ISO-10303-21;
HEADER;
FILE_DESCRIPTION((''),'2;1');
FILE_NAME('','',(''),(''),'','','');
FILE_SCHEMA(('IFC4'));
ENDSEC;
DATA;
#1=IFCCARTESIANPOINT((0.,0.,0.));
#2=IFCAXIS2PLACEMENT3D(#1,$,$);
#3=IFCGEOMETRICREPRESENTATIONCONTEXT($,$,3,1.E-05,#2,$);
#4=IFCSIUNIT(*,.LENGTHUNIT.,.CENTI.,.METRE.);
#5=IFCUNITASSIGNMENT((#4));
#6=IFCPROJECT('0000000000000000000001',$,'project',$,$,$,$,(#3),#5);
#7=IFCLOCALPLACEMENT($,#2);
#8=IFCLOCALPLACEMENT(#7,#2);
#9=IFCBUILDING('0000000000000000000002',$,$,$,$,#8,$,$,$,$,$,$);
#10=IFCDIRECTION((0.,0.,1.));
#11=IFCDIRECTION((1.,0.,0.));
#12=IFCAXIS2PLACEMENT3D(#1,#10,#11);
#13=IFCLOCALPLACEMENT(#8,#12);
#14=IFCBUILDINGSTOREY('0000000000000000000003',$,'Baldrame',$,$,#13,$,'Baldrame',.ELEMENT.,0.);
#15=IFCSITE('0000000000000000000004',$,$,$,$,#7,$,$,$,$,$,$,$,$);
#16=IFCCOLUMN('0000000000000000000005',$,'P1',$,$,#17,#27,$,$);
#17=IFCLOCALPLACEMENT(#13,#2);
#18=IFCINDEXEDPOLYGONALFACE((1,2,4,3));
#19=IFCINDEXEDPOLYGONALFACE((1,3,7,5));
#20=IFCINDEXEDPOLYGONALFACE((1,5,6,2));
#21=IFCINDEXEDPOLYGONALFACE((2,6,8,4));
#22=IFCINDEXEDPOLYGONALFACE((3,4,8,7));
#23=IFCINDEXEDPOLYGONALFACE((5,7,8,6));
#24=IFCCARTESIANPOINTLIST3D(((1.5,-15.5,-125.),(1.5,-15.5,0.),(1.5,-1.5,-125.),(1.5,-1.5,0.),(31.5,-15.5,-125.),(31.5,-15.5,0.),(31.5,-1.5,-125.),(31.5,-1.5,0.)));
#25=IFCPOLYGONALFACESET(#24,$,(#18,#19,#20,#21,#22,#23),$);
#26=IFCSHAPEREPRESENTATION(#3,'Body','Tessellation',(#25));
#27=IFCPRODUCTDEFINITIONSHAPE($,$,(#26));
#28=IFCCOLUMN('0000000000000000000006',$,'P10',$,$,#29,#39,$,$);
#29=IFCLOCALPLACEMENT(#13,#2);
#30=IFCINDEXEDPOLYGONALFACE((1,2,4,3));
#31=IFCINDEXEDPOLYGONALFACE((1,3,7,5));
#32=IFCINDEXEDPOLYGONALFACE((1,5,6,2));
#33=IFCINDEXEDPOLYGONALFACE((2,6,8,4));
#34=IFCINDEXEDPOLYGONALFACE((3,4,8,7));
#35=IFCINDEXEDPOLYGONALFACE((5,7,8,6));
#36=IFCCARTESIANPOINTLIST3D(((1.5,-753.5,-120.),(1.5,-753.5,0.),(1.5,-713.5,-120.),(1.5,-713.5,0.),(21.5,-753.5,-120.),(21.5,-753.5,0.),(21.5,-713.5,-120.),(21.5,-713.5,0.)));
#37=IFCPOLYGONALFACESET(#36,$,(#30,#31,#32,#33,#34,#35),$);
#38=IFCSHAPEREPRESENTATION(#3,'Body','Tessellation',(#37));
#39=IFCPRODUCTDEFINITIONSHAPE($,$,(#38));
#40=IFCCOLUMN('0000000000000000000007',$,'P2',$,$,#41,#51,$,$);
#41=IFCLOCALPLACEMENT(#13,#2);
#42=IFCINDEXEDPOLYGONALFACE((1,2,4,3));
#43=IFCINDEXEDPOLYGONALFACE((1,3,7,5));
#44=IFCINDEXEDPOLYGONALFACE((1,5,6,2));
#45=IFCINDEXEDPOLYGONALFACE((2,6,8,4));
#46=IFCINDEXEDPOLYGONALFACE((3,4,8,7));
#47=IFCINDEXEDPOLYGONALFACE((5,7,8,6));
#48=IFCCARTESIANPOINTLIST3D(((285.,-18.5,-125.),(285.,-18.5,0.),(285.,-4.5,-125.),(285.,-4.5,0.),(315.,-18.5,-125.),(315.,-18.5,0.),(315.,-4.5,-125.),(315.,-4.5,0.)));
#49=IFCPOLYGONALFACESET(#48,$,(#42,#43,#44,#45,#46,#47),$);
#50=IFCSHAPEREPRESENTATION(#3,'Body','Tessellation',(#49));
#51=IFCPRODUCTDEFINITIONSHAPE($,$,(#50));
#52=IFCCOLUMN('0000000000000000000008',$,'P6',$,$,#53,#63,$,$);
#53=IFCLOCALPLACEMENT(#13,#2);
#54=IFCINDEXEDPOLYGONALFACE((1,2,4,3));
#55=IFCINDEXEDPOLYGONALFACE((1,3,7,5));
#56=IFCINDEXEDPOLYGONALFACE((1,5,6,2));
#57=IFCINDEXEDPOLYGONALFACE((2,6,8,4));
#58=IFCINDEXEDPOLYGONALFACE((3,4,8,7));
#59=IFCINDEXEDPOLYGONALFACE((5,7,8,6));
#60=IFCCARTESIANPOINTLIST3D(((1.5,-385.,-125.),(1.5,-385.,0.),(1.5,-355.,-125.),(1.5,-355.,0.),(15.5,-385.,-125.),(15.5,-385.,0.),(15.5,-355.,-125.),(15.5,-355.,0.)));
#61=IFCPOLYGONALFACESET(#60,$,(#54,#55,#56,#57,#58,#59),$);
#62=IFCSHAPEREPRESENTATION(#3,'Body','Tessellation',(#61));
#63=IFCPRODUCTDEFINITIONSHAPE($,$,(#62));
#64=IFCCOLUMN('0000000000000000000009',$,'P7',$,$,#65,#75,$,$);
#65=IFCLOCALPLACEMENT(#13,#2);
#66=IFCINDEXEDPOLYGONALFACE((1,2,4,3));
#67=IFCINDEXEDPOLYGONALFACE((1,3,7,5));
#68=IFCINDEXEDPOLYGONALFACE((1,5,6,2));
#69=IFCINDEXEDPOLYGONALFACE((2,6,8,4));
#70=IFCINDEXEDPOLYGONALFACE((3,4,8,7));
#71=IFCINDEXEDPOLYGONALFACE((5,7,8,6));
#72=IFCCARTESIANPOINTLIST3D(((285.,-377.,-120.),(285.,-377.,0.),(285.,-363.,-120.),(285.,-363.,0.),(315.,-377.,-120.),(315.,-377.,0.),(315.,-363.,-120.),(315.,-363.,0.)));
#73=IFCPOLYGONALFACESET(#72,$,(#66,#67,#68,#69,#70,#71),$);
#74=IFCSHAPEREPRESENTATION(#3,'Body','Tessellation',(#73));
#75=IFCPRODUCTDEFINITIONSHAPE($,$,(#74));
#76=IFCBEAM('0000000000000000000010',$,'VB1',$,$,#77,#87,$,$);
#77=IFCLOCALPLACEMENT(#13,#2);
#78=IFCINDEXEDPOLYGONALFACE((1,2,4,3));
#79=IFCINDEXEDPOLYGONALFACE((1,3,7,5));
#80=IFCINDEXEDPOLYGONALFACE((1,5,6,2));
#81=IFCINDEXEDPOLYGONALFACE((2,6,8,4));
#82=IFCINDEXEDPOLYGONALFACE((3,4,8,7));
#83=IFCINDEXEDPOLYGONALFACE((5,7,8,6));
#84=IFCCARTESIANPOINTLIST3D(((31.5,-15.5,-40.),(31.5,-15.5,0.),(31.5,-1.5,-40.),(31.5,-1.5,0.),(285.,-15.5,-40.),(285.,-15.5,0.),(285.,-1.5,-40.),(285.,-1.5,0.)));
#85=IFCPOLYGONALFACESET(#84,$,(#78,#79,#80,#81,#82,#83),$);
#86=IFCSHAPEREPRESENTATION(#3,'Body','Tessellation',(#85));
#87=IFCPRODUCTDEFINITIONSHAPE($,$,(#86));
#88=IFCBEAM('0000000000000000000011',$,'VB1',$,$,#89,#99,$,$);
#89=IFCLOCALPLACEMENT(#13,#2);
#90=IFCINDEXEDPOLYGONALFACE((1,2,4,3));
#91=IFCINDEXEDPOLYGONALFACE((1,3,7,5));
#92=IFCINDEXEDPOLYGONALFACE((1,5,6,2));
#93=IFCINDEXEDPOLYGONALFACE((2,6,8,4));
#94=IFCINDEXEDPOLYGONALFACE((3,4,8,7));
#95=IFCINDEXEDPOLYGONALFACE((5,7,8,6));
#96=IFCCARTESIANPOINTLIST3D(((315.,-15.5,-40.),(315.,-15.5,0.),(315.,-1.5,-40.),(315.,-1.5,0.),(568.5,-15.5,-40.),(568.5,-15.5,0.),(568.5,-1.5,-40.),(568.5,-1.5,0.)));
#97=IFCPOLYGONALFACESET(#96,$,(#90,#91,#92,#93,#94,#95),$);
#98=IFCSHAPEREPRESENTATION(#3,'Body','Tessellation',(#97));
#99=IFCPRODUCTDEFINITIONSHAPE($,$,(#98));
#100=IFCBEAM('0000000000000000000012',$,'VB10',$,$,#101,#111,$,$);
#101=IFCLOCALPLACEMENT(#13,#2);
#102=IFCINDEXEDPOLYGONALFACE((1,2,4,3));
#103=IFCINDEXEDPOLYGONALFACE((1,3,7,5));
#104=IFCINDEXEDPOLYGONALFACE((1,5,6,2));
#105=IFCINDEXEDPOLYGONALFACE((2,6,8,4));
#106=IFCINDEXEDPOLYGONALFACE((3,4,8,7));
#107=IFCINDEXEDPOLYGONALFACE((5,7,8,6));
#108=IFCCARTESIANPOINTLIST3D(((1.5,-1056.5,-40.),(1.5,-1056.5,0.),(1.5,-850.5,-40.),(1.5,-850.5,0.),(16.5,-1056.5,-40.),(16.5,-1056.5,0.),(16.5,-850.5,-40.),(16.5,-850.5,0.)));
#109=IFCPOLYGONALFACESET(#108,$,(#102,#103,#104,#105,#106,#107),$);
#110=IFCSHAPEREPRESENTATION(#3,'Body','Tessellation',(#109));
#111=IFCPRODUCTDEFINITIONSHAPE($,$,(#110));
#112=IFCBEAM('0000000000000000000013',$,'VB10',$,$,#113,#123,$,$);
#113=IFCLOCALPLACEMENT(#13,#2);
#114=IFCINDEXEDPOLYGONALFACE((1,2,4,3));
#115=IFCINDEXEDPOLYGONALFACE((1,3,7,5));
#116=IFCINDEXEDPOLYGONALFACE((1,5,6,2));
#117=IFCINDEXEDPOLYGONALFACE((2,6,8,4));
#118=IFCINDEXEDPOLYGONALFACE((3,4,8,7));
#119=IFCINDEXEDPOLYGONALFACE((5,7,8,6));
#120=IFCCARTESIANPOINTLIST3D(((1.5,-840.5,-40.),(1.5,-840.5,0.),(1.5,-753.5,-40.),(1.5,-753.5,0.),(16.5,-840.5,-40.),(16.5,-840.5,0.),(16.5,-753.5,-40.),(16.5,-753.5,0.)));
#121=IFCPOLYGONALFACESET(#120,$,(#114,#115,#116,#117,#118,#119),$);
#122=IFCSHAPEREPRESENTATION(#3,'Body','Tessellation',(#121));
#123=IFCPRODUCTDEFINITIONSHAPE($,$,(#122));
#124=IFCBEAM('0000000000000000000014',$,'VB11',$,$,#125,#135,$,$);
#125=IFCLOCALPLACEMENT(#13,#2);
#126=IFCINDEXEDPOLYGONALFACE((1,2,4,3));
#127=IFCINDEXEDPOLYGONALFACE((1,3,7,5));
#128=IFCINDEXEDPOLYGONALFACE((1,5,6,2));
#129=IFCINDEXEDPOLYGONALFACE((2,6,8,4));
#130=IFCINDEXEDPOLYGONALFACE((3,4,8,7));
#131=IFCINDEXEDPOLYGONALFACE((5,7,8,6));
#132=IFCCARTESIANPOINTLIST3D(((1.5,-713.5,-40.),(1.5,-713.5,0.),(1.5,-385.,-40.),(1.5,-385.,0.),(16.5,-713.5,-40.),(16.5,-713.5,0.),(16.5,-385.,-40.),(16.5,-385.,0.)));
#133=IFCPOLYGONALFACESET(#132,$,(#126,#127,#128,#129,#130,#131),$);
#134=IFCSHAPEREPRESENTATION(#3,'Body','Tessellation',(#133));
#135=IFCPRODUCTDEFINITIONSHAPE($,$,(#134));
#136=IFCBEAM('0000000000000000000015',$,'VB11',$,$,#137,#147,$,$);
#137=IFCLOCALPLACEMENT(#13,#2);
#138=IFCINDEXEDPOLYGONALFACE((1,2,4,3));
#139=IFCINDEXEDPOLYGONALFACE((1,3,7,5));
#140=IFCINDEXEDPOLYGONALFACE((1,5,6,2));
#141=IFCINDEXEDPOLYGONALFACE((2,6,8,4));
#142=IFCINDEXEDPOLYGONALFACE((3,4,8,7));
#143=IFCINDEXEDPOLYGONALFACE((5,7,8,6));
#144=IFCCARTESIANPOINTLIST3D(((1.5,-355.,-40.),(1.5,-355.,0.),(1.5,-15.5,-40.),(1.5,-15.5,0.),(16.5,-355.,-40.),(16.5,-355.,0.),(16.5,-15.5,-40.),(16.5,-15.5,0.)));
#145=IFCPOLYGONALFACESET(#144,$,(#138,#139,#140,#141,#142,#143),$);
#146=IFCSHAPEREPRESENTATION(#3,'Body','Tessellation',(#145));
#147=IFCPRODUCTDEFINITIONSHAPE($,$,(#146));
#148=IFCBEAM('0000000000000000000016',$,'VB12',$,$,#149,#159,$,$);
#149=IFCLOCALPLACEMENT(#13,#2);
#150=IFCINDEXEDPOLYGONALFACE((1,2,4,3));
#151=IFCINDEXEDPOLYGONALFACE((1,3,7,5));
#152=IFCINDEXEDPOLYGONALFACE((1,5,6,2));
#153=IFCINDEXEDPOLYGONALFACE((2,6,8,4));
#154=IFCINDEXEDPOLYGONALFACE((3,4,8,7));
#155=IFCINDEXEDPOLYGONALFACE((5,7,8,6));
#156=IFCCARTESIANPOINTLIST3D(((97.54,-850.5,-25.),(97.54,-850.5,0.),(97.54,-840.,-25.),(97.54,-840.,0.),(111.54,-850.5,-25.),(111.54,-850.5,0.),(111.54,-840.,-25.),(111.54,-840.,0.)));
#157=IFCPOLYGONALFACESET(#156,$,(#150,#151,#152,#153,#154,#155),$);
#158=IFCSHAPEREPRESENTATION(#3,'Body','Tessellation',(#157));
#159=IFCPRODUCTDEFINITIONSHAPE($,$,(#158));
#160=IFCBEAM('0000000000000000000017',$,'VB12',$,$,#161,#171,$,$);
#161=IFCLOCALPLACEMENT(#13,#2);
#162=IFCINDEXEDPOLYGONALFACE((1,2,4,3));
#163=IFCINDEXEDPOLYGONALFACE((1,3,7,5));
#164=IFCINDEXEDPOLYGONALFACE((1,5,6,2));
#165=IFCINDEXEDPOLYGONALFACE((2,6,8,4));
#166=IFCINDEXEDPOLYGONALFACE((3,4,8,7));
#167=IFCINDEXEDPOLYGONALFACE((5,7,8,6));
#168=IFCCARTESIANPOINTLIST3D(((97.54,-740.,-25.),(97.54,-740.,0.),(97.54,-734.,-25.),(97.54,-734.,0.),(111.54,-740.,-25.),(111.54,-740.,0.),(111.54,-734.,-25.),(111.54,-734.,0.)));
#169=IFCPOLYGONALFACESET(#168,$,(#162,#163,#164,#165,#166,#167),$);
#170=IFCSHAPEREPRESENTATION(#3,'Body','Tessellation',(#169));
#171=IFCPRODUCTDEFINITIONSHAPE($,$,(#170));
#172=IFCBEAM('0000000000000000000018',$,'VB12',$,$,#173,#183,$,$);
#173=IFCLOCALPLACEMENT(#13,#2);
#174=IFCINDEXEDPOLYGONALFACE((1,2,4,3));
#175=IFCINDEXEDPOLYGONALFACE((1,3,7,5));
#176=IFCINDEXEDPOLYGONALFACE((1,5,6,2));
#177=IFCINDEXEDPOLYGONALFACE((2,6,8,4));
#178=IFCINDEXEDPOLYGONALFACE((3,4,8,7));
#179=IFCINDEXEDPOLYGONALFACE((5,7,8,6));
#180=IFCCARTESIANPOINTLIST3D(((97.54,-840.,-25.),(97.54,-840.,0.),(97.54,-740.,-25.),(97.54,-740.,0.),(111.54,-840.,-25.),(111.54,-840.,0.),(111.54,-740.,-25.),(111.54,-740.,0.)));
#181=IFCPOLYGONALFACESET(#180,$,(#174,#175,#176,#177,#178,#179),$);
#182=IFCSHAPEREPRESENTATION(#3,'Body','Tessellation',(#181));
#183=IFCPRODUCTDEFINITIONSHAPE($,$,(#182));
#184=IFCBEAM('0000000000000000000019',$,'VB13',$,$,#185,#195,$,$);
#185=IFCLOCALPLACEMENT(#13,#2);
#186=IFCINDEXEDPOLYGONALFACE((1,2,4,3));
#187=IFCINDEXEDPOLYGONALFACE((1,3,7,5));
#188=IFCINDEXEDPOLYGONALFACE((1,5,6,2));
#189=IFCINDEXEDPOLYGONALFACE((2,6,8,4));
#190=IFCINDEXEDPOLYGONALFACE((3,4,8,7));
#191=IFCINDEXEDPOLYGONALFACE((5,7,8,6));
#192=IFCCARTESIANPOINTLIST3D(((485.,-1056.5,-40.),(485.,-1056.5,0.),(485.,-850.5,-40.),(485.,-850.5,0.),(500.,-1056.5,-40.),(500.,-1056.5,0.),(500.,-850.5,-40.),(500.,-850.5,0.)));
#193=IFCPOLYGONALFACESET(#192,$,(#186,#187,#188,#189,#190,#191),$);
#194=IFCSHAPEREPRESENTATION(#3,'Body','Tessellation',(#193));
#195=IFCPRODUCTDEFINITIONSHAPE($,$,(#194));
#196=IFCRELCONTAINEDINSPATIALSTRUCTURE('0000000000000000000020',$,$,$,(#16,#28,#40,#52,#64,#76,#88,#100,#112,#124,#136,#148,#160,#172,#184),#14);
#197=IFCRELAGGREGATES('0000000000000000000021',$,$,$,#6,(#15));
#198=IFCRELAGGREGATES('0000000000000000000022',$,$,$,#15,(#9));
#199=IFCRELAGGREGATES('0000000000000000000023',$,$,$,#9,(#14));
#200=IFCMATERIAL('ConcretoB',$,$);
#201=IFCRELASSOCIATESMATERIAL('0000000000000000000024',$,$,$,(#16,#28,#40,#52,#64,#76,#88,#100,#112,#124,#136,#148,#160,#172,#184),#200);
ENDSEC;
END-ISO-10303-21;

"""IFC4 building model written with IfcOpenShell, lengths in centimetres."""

from ifc_helpers import new_model, si_unit, frame, origin, origin_with_axes, place, context, project, spatial, polyline, outline, extrude, material, element, save


model = new_model("IFC4")

# Units and contexts
context_of_model = context(None, 3, precision=1e-05, world=origin())
ifc_project = project(units=[si_unit("LENGTHUNIT", "METRE", prefix="CENTI")], contexts=[context_of_model])

# Site, building, storey
site_placement = place(None, origin())
site = spatial("IfcSite", under=ifc_project, at=site_placement)
building_placement = place(site_placement, origin())
building = spatial("IfcBuilding", under=site, at=building_placement)
storey_placement = place(building_placement, origin_with_axes())
storey = spatial("IfcBuildingStorey", under=building, at=storey_placement, Name="Baldrame", LongName="Baldrame", CompositionType="ELEMENT", Elevation=0.0)

# Columns
ifc_material = material(Name="ConcretoB")
column_1_placement = place(storey_placement, frame((16.5, -8.5, 0.0), z_axis=(0.0, 0.0, 1.0), x_axis=(1.0, 0.0, 0.0)))
element("IfcColumn", 1, at=column_1_placement, inside=storey, material=ifc_material, Name="P1", context=context_of_model, shape_type="SolidModel", body=[
    extrude(outline(polyline([(-15.0, 7.0), (-15.0, -7.0), (15.0, -7.0), (15.0, 7.0), (-15.0, 7.0)])), frame((0.0, 0.0, -125.0), z_axis=(0.0, 0.0, 1.0), x_axis=(1.0, 0.0, 0.0)), (0.0, 0.0, 1.0), 125.0),
])
column_2_placement = place(storey_placement, frame((11.5, -733.5, 0.0), z_axis=(0.0, 0.0, 1.0), x_axis=(1.0, 0.0, 0.0)))
element("IfcColumn", 2, at=column_2_placement, inside=storey, material=ifc_material, Name="P10", context=context_of_model, shape_type="SolidModel", body=[
    extrude(outline(polyline([(10.0, 20.0), (-10.0, 20.0), (-10.0, -20.0), (10.0, -20.0), (10.0, 20.0)])), frame((0.0, 0.0, -120.0), z_axis=(0.0, 0.0, 1.0), x_axis=(1.0, 0.0, 0.0)), (0.0, 0.0, 1.0), 120.0),
])
column_3_placement = place(storey_placement, frame((300.0, -11.5, 0.0), z_axis=(0.0, 0.0, 1.0), x_axis=(1.0, 0.0, 0.0)))
element("IfcColumn", 3, at=column_3_placement, inside=storey, material=ifc_material, Name="P2", context=context_of_model, shape_type="SolidModel", body=[
    extrude(outline(polyline([(15.0, -7.0), (15.0, 7.0), (-15.0, 7.0), (-15.0, -7.0), (15.0, -7.0)])), frame((0.0, 0.0, -125.0), z_axis=(0.0, 0.0, 1.0), x_axis=(1.0, 0.0, 0.0)), (0.0, 0.0, 1.0), 125.0),
])
column_4_placement = place(storey_placement, frame((8.5, -370.0, 0.0), z_axis=(0.0, 0.0, 1.0), x_axis=(1.0, 0.0, 0.0)))
element("IfcColumn", 4, at=column_4_placement, inside=storey, material=ifc_material, Name="P6", context=context_of_model, shape_type="SolidModel", body=[
    extrude(outline(polyline([(-7.0, -15.0), (7.0, -15.0), (7.0, 15.0), (-7.0, 15.0), (-7.0, -15.0)])), frame((0.0, 0.0, -125.0), z_axis=(0.0, 0.0, 1.0), x_axis=(1.0, 0.0, 0.0)), (0.0, 0.0, 1.0), 125.0),
])
column_5_placement = place(storey_placement, frame((300.0, -370.0, 0.0), z_axis=(0.0, 0.0, 1.0), x_axis=(1.0, 0.0, 0.0)))
element("IfcColumn", 5, at=column_5_placement, inside=storey, material=ifc_material, Name="P7", context=context_of_model, shape_type="SolidModel", body=[
    extrude(outline(polyline([(15.0, -7.0), (15.0, 7.0), (-15.0, 7.0), (-15.0, -7.0), (15.0, -7.0)])), frame((0.0, 0.0, -120.0), z_axis=(0.0, 0.0, 1.0), x_axis=(1.0, 0.0, 0.0)), (0.0, 0.0, 1.0), 120.0),
])

# Beams
for number, where, z_axis, x_axis, name in (
    (6, (158.25, -8.5, 0.0), (0.0, 0.0, 1.0), (1.0, 0.0, 0.0), "VB1"),
    (7, (441.75, -8.5, 0.0), (0.0, 0.0, 1.0), (1.0, 0.0, 0.0), "VB1"),
):
    element("IfcBeam", number, at=place(storey_placement, frame(where, z_axis=z_axis, x_axis=x_axis)), inside=storey, material=ifc_material, Name=name, context=context_of_model, shape_type="SolidModel", body=[
        extrude(outline(polyline([(7.0, 20.0), (-7.0, 20.0), (-7.0, -20.0), (7.0, -20.0), (7.0, 20.0)])), frame((-126.75, 0.0, -20.0), z_axis=(1.0, 0.0, 0.0), x_axis=(0.0, 1.0, 0.0)), (0.0, 0.0, 1.0), 253.5),
    ])
beam_1_placement = place(storey_placement, frame((9.0, -953.5, 0.0), z_axis=(0.0, 0.0, 1.0), x_axis=(1.0, 0.0, 0.0)))
element("IfcBeam", 8, at=beam_1_placement, inside=storey, material=ifc_material, Name="VB10", context=context_of_model, shape_type="SolidModel", body=[
    extrude(outline(polyline([(-7.5, -20.0), (7.5, -20.0), (7.5, 20.0), (-7.5, 20.0), (-7.5, -20.0)])), frame((0.0, -103.0, -20.0), z_axis=(0.0, 1.0, 0.0), x_axis=(1.0, 0.0, 0.0)), (0.0, 0.0, 1.0), 206.0),
])
beam_2_placement = place(storey_placement, frame((9.0, -797.0, 0.0), z_axis=(0.0, 0.0, 1.0), x_axis=(1.0, 0.0, 0.0)))
element("IfcBeam", 9, at=beam_2_placement, inside=storey, material=ifc_material, Name="VB10", context=context_of_model, shape_type="SolidModel", body=[
    extrude(outline(polyline([(-7.5, -20.0), (7.5, -20.0), (7.5, 20.0), (-7.5, 20.0), (-7.5, -20.0)])), frame((0.0, -43.5, -20.0), z_axis=(0.0, 1.0, 0.0), x_axis=(1.0, 0.0, 0.0)), (0.0, 0.0, 1.0), 87.0),
])
beam_3_placement = place(storey_placement, frame((9.0, -549.25, 0.0), z_axis=(0.0, 0.0, 1.0), x_axis=(1.0, 0.0, 0.0)))
element("IfcBeam", 10, at=beam_3_placement, inside=storey, material=ifc_material, Name="VB11", context=context_of_model, shape_type="SolidModel", body=[
    extrude(outline(polyline([(-7.5, -20.0), (7.5, -20.0), (7.5, 20.0), (-7.5, 20.0), (-7.5, -20.0)])), frame((0.0, -164.25, -20.0), z_axis=(0.0, 1.0, 0.0), x_axis=(1.0, 0.0, 0.0)), (0.0, 0.0, 1.0), 328.5),
])
beam_4_placement = place(storey_placement, frame((9.0, -185.25, 0.0), z_axis=(0.0, 0.0, 1.0), x_axis=(1.0, 0.0, 0.0)))
element("IfcBeam", 11, at=beam_4_placement, inside=storey, material=ifc_material, Name="VB11", context=context_of_model, shape_type="SolidModel", body=[
    extrude(outline(polyline([(-7.5, -20.0), (7.5, -20.0), (7.5, 20.0), (-7.5, 20.0), (-7.5, -20.0)])), frame((0.0, -169.75, -20.0), z_axis=(0.0, 1.0, 0.0), x_axis=(1.0, 0.0, 0.0)), (0.0, 0.0, 1.0), 339.5),
])
beam_5_placement = place(storey_placement, frame((104.54, -845.25, 0.0), z_axis=(0.0, 0.0, 1.0), x_axis=(1.0, 0.0, 0.0)))
element("IfcBeam", 12, at=beam_5_placement, inside=storey, material=ifc_material, Name="VB12", context=context_of_model, shape_type="SolidModel", body=[
    extrude(outline(polyline([(-7.0, -12.5), (7.0, -12.5), (7.0, 12.5), (-7.0, 12.5), (-7.0, -12.5)])), frame((0.0, -5.25, -12.5), z_axis=(0.0, 1.0, 0.0), x_axis=(1.0, 0.0, 0.0)), (0.0, 0.0, 1.0), 10.5),
])
beam_6_placement = place(storey_placement, frame((104.54, -737.0, 0.0), z_axis=(0.0, 0.0, 1.0), x_axis=(1.0, 0.0, 0.0)))
element("IfcBeam", 13, at=beam_6_placement, inside=storey, material=ifc_material, Name="VB12", context=context_of_model, shape_type="SolidModel", body=[
    extrude(outline(polyline([(-7.0, -12.5), (7.0, -12.5), (7.0, 12.5), (-7.0, 12.5), (-7.0, -12.5)])), frame((0.0, -3.0, -12.5), z_axis=(0.0, 1.0, 0.0), x_axis=(1.0, 0.0, 0.0)), (0.0, 0.0, 1.0), 6.0),
])
beam_7_placement = place(storey_placement, frame((104.54, -790.0, 0.0), z_axis=(0.0, 0.0, 1.0), x_axis=(1.0, 0.0, 0.0)))
element("IfcBeam", 14, at=beam_7_placement, inside=storey, material=ifc_material, Name="VB12", context=context_of_model, shape_type="SolidModel", body=[
    extrude(outline(polyline([(-7.0, -12.5), (7.0, -12.5), (7.0, 12.5), (-7.0, 12.5), (-7.0, -12.5)])), frame((0.0, -50.0, -12.5), z_axis=(0.0, 1.0, 0.0), x_axis=(1.0, 0.0, 0.0)), (0.0, 0.0, 1.0), 100.0),
])
beam_8_placement = place(storey_placement, frame((492.5, -953.5, 0.0), z_axis=(0.0, 0.0, 1.0), x_axis=(1.0, 0.0, 0.0)))
element("IfcBeam", 15, at=beam_8_placement, inside=storey, material=ifc_material, Name="VB13", context=context_of_model, shape_type="SolidModel", body=[
    extrude(outline(polyline([(-7.5, -20.0), (7.5, -20.0), (7.5, 20.0), (-7.5, 20.0), (-7.5, -20.0)])), frame((0.0, -103.0, -20.0), z_axis=(0.0, 1.0, 0.0), x_axis=(1.0, 0.0, 0.0)), (0.0, 0.0, 1.0), 206.0),
])

save(model, "model.ifc")
